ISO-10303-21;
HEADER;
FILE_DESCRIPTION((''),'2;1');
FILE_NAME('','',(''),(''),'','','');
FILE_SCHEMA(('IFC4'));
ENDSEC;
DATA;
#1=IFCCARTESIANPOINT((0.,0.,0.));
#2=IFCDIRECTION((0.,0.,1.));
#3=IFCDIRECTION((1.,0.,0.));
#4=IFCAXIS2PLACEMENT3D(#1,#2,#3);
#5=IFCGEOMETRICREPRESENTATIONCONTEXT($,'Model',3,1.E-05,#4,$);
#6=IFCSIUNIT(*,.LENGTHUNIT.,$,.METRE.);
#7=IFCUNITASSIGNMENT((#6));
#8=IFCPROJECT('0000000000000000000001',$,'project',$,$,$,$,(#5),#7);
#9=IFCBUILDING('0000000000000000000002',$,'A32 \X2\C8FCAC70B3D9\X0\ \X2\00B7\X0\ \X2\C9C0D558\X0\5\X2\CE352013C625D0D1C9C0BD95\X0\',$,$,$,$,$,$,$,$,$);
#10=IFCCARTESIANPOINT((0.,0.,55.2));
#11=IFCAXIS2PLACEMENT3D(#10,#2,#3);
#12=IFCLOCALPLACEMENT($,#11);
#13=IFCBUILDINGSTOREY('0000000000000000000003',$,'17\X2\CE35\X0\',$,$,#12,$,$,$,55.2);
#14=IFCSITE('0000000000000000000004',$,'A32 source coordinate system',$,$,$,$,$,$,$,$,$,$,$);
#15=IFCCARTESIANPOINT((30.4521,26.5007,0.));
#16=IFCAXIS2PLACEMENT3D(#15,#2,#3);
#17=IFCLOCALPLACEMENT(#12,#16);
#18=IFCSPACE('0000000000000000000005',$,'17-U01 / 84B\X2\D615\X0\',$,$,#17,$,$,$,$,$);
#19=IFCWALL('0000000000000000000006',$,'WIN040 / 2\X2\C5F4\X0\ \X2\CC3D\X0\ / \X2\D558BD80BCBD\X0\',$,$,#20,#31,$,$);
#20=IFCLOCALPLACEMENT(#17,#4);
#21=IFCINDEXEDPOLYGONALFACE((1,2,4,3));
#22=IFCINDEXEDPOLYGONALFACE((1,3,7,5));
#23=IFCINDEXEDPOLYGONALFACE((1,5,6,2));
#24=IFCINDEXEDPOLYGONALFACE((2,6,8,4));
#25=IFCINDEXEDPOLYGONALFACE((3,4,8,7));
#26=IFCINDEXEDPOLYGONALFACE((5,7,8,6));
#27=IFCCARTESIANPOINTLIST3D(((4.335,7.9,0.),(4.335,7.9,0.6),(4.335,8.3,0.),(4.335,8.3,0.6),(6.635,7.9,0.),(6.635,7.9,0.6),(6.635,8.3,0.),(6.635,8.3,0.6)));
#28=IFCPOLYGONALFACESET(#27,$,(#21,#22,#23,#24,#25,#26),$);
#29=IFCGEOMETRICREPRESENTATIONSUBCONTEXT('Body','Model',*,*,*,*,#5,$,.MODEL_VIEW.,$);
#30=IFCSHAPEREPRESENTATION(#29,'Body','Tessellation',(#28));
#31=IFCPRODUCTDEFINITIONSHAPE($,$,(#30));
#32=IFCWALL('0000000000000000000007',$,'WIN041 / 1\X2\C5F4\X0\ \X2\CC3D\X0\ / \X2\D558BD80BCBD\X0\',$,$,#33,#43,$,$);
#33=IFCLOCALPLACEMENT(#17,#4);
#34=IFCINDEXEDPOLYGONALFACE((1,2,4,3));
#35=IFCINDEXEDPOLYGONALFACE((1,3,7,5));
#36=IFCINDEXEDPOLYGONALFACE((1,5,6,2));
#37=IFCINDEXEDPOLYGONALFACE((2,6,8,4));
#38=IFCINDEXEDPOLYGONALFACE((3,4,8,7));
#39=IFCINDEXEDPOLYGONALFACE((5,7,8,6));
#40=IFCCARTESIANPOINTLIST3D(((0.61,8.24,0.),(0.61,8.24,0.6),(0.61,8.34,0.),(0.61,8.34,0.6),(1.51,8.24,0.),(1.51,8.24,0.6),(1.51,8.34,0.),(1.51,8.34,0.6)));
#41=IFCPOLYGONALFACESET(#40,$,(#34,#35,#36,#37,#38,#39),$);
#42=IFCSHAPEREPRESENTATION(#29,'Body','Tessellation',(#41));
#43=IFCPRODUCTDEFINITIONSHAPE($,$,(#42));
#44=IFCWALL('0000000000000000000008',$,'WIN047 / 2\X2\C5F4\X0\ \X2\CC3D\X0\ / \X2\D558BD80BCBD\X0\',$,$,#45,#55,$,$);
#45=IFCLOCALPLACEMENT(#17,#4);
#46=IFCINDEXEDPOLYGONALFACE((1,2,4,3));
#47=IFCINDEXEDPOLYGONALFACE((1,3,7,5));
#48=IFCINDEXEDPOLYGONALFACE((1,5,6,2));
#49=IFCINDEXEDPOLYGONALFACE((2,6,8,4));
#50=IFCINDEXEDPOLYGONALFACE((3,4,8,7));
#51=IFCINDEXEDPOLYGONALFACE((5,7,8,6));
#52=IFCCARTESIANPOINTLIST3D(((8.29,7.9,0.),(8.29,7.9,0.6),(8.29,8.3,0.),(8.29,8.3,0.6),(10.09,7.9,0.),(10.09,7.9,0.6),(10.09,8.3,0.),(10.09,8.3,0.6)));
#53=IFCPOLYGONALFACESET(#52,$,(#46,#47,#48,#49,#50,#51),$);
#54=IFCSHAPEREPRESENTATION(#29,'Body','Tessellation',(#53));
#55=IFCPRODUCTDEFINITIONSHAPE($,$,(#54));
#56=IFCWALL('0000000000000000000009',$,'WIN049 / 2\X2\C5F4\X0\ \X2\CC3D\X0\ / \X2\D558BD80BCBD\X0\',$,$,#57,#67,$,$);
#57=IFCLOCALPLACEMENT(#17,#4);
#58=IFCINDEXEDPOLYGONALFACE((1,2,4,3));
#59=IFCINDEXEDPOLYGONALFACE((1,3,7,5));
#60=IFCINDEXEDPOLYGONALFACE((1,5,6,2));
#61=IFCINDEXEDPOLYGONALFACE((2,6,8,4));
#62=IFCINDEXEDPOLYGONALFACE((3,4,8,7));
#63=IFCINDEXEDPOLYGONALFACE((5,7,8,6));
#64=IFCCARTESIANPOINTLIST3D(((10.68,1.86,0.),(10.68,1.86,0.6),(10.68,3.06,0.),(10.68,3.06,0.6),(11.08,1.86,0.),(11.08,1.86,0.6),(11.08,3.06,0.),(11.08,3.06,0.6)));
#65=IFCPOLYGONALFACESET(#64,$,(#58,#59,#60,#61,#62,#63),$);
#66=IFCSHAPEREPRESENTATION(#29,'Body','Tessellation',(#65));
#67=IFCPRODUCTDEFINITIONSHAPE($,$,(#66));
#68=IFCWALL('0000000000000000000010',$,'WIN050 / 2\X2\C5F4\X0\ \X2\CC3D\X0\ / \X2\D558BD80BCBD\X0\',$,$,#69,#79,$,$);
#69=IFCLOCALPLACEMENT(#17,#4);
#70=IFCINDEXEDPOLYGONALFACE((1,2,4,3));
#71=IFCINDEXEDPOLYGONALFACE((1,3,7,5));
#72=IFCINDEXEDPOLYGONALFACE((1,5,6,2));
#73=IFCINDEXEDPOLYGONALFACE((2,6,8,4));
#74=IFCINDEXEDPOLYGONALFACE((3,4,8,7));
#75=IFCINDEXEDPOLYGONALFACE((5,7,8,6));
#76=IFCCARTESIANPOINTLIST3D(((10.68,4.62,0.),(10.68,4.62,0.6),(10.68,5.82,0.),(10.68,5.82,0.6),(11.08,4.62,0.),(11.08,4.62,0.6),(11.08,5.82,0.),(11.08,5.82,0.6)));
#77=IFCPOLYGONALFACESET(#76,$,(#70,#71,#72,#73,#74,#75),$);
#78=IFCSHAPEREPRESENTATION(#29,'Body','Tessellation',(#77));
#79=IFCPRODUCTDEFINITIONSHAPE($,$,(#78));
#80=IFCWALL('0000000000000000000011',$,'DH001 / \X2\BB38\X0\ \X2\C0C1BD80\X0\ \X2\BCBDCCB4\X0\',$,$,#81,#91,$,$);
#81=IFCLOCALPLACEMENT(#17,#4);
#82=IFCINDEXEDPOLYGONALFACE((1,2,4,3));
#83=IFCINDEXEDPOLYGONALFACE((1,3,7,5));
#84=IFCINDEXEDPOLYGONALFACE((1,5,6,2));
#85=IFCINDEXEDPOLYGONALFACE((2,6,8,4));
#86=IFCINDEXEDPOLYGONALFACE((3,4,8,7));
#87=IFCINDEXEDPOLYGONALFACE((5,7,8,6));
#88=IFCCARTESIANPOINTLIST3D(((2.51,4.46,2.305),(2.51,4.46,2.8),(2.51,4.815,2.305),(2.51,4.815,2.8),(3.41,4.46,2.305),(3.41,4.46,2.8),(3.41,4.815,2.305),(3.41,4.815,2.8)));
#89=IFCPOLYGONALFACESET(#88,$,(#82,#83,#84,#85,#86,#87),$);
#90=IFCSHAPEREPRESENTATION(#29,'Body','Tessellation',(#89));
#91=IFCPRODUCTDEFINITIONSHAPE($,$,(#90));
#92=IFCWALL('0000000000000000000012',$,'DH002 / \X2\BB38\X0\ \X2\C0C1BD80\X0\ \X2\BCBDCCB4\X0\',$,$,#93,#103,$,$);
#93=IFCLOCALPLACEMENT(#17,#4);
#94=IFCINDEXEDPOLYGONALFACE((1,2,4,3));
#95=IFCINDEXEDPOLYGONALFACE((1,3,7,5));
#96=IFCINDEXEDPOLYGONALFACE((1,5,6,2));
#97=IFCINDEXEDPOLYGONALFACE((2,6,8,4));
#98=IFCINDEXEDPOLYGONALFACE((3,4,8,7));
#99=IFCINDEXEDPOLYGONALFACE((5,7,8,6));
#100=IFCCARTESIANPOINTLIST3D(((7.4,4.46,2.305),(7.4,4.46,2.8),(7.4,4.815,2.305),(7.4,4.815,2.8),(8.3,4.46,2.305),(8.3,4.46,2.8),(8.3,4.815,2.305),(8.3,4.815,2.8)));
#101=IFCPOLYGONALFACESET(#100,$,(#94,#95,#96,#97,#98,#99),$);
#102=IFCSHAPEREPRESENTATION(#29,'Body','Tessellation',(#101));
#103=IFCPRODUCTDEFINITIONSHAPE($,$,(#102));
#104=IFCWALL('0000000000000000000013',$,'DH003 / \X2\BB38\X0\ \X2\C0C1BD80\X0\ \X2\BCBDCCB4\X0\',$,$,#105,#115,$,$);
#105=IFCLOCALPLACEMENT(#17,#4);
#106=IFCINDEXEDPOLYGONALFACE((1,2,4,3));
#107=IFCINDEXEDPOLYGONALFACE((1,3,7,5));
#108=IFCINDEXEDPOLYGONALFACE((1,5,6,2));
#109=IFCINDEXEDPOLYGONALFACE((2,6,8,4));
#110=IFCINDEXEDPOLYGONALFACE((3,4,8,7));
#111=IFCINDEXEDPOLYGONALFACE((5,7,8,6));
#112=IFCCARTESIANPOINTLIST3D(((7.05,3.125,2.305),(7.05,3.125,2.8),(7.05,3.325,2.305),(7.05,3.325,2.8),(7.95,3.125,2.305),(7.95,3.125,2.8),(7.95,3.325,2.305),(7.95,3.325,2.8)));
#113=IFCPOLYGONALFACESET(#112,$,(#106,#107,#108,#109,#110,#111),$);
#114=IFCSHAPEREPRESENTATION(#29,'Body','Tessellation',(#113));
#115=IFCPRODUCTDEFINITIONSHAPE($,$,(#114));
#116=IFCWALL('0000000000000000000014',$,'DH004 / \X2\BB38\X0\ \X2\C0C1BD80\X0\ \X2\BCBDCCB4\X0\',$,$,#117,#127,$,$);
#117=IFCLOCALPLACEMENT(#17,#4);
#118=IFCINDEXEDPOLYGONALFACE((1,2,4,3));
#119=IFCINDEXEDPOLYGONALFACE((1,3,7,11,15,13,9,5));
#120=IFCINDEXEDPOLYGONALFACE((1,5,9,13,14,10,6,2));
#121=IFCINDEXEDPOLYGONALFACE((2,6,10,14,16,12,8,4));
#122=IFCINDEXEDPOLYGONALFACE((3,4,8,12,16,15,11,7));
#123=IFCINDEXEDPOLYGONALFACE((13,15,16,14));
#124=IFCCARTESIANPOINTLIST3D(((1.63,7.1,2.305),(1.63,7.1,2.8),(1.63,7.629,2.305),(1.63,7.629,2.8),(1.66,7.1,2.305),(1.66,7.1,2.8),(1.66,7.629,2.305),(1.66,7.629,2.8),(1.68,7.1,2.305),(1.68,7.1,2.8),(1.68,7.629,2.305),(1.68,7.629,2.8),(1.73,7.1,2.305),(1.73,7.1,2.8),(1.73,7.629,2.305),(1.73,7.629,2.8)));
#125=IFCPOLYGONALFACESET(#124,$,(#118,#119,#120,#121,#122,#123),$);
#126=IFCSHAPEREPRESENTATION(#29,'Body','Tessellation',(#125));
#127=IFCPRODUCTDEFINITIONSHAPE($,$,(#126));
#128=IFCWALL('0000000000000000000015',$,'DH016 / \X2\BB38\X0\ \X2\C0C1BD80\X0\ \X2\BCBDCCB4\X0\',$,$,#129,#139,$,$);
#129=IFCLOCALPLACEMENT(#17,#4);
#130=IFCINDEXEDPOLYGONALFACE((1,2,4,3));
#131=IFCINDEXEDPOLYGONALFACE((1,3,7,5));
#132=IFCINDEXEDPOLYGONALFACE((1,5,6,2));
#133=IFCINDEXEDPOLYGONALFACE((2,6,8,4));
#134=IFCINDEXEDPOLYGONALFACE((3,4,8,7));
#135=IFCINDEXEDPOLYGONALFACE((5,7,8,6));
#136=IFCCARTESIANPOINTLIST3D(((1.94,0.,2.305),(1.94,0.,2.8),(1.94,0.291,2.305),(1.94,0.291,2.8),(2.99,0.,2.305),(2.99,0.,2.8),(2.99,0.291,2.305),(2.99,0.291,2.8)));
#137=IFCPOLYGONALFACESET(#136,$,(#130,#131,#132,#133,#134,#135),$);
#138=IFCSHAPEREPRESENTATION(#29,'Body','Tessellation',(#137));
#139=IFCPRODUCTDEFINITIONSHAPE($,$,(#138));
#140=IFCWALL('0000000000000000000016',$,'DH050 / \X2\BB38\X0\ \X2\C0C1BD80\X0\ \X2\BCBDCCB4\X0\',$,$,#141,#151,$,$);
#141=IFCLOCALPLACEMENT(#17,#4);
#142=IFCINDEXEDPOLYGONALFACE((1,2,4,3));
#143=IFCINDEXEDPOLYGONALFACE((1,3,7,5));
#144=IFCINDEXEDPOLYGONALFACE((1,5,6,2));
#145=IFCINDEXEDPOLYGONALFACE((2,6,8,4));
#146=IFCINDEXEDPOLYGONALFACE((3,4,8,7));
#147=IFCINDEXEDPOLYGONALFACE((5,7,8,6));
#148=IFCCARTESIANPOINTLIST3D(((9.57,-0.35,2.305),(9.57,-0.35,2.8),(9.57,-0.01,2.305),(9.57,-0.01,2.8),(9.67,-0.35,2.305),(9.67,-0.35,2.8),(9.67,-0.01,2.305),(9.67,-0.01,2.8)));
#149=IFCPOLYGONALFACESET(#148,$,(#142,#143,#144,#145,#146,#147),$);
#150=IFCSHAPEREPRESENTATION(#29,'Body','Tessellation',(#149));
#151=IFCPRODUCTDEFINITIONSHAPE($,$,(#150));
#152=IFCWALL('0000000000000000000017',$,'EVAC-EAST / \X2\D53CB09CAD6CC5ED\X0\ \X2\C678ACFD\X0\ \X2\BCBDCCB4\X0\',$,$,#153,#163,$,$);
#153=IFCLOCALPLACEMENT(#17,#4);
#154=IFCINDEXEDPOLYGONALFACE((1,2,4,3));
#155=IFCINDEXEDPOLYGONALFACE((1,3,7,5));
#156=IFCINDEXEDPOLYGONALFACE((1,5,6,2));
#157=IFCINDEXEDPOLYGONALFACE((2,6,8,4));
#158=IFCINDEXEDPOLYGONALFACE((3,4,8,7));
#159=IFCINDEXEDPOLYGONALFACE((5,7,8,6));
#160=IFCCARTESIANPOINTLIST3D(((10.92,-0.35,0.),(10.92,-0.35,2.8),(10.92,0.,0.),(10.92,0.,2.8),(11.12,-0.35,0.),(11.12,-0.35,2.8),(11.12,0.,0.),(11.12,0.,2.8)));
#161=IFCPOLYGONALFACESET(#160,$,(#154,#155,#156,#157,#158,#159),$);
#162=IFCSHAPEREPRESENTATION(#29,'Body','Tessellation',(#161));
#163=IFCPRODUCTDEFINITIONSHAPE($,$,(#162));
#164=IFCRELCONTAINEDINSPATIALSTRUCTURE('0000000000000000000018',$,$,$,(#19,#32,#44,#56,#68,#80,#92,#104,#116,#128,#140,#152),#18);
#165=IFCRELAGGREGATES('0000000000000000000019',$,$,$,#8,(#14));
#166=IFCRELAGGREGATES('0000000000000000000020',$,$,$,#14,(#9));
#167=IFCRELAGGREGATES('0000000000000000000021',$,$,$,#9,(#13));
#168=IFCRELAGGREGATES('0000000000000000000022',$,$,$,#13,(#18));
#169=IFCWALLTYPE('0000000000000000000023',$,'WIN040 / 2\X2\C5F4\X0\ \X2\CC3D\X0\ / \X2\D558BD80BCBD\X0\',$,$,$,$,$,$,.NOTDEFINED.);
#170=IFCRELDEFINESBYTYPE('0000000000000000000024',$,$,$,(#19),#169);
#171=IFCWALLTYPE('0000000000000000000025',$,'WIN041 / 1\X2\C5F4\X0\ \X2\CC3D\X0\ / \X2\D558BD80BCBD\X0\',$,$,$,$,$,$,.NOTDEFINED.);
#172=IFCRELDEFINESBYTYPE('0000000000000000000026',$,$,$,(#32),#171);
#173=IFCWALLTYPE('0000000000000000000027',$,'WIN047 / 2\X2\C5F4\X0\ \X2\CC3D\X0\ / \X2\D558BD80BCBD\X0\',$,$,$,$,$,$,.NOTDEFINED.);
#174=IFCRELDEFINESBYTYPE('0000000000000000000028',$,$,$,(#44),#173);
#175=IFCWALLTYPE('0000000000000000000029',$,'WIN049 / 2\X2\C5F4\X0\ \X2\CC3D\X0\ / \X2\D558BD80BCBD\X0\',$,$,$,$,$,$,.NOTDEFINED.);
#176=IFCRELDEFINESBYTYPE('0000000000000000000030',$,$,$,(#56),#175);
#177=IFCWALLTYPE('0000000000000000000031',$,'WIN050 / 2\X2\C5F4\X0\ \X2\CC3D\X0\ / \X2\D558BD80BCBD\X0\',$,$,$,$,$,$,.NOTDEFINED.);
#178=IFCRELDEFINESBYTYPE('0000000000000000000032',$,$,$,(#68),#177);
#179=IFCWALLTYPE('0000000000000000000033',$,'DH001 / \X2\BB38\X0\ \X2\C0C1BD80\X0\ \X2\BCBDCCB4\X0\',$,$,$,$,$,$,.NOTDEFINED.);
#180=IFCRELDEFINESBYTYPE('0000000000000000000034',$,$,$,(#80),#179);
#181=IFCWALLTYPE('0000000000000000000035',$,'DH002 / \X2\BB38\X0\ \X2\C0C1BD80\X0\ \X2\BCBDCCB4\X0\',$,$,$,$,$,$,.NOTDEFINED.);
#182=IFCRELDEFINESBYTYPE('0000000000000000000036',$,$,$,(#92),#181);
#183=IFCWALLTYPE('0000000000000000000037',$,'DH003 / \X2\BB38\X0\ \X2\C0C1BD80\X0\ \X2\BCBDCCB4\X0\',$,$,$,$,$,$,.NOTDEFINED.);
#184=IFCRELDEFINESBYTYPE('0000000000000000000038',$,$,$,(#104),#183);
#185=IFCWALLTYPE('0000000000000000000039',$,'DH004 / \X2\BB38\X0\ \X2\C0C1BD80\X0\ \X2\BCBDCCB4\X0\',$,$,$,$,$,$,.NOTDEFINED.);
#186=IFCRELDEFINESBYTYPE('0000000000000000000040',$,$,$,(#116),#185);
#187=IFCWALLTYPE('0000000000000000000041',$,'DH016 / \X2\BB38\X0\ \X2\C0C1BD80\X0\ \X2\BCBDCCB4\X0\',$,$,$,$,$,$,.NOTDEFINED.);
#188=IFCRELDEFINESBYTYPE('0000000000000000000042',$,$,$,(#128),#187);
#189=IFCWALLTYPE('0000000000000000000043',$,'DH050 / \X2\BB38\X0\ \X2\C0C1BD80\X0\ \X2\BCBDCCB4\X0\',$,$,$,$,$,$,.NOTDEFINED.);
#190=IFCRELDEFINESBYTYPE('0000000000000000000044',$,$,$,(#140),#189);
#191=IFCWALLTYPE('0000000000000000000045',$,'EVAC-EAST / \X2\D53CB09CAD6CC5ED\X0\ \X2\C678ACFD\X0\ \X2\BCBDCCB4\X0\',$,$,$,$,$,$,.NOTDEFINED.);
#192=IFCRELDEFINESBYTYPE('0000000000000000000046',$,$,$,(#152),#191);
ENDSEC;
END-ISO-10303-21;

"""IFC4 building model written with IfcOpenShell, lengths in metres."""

from ifc_helpers import new_model, si_unit, frame, origin, origin_with_axes, place, context, subcontext, project, spatial, polyline, outline, extrude, source, transform, mapped, type_object, type_shapes, element, save


model = new_model("IFC4")

# Units and contexts
model_context = context("Model", 3, precision=1e-05, world=origin_with_axes())
body_context = subcontext(model_context, "Body", "Model", "MODEL_VIEW")
ifc_project = project(units=[si_unit("LENGTHUNIT", "METRE")], contexts=[model_context])

# Site, building, storey, space
site = spatial("IfcSite", under=ifc_project, Name="A32 source coordinate system")
building = spatial("IfcBuilding", under=site, Name="A32 주거동 · 지하5층–옥탑지붕")
storey_placement = place(None, frame((0.0, 0.0, 55.2), z_axis=(0.0, 0.0, 1.0), x_axis=(1.0, 0.0, 0.0)))
storey = spatial("IfcBuildingStorey", under=building, at=storey_placement, Name="17층", Elevation=55.2)
space_placement = place(storey_placement, frame((30.4521, 26.5007, 0.0), z_axis=(0.0, 0.0, 1.0), x_axis=(1.0, 0.0, 0.0)))
space = spatial("IfcSpace", under=storey, at=space_placement, Name="17-U01 / 84B형")

# Walls
wall_type_1 = type_object("IfcWallType", Name="WIN040 / 2열 창 / 하부벽", PredefinedType="NOTDEFINED")
shared_shape_1 = source(origin(), body_context, "Body", "SweptSolid", [
    extrude(outline(polyline([(4.335, 8.3), (6.635, 8.3), (6.635, 7.9), (4.335, 7.9), (4.335, 8.3)])), origin(), (0.0, 0.0, 1.0), 0.6),
])
type_shapes(wall_type_1, [shared_shape_1])
wall_1_placement = place(space_placement, origin_with_axes())
element("IfcWall", 1, at=wall_1_placement, inside=space, type_object=wall_type_1, Name="WIN040 / 2열 창 / 하부벽", context=body_context, shape_type="MappedRepresentation", body=[
    mapped(shared_shape_1, transform((0.0, 0.0, 0.0), scale=1.0)),
])
wall_type_2 = type_object("IfcWallType", Name="WIN041 / 1열 창 / 하부벽", PredefinedType="NOTDEFINED")
shared_shape_2 = source(origin(), body_context, "Body", "SweptSolid", [
    extrude(outline(polyline([(0.61, 8.34), (1.51, 8.34), (1.51, 8.24), (0.61, 8.24), (0.61, 8.34)])), origin(), (0.0, 0.0, 1.0), 0.6),
])
type_shapes(wall_type_2, [shared_shape_2])
wall_2_placement = place(space_placement, origin_with_axes())
element("IfcWall", 2, at=wall_2_placement, inside=space, type_object=wall_type_2, Name="WIN041 / 1열 창 / 하부벽", context=body_context, shape_type="MappedRepresentation", body=[
    mapped(shared_shape_2, transform((0.0, 0.0, 0.0), scale=1.0)),
])
wall_type_3 = type_object("IfcWallType", Name="WIN047 / 2열 창 / 하부벽", PredefinedType="NOTDEFINED")
shared_shape_3 = source(origin(), body_context, "Body", "SweptSolid", [
    extrude(outline(polyline([(8.29, 8.3), (10.09, 8.3), (10.09, 7.9), (8.29, 7.9), (8.29, 8.3)])), origin(), (0.0, 0.0, 1.0), 0.6),
])
type_shapes(wall_type_3, [shared_shape_3])
wall_3_placement = place(space_placement, origin_with_axes())
element("IfcWall", 3, at=wall_3_placement, inside=space, type_object=wall_type_3, Name="WIN047 / 2열 창 / 하부벽", context=body_context, shape_type="MappedRepresentation", body=[
    mapped(shared_shape_3, transform((0.0, 0.0, 0.0), scale=1.0)),
])
wall_type_4 = type_object("IfcWallType", Name="WIN049 / 2열 창 / 하부벽", PredefinedType="NOTDEFINED")
shared_shape_4 = source(origin(), body_context, "Body", "SweptSolid", [
    extrude(outline(polyline([(10.68, 3.06), (11.08, 3.06), (11.08, 1.86), (10.68, 1.86), (10.68, 3.06)])), origin(), (0.0, 0.0, 1.0), 0.6),
])
type_shapes(wall_type_4, [shared_shape_4])
wall_4_placement = place(space_placement, origin_with_axes())
element("IfcWall", 4, at=wall_4_placement, inside=space, type_object=wall_type_4, Name="WIN049 / 2열 창 / 하부벽", context=body_context, shape_type="MappedRepresentation", body=[
    mapped(shared_shape_4, transform((0.0, 0.0, 0.0), scale=1.0)),
])
wall_type_5 = type_object("IfcWallType", Name="WIN050 / 2열 창 / 하부벽", PredefinedType="NOTDEFINED")
shared_shape_5 = source(origin(), body_context, "Body", "SweptSolid", [
    extrude(outline(polyline([(10.68, 5.82), (11.08, 5.82), (11.08, 4.62), (10.68, 4.62), (10.68, 5.82)])), origin(), (0.0, 0.0, 1.0), 0.6),
])
type_shapes(wall_type_5, [shared_shape_5])
wall_5_placement = place(space_placement, origin_with_axes())
element("IfcWall", 5, at=wall_5_placement, inside=space, type_object=wall_type_5, Name="WIN050 / 2열 창 / 하부벽", context=body_context, shape_type="MappedRepresentation", body=[
    mapped(shared_shape_5, transform((0.0, 0.0, 0.0), scale=1.0)),
])
wall_type_6 = type_object("IfcWallType", Name="DH001 / 문 상부 벽체", PredefinedType="NOTDEFINED")
shared_shape_6 = source(origin(), body_context, "Body", "SweptSolid", [
    extrude(outline(polyline([(3.41, 4.815), (3.41, 4.46), (2.51, 4.46), (2.51, 4.815), (3.41, 4.815)])), frame((0.0, 0.0, 2.305)), (0.0, 0.0, 1.0), 0.495),
])
type_shapes(wall_type_6, [shared_shape_6])
wall_6_placement = place(space_placement, origin_with_axes())
element("IfcWall", 6, at=wall_6_placement, inside=space, type_object=wall_type_6, Name="DH001 / 문 상부 벽체", context=body_context, shape_type="MappedRepresentation", body=[
    mapped(shared_shape_6, transform((0.0, 0.0, 0.0), scale=1.0)),
])
wall_type_7 = type_object("IfcWallType", Name="DH002 / 문 상부 벽체", PredefinedType="NOTDEFINED")
shared_shape_7 = source(origin(), body_context, "Body", "SweptSolid", [
    extrude(outline(polyline([(8.3, 4.815), (8.3, 4.46), (7.4, 4.46), (7.4, 4.815), (8.3, 4.815)])), frame((0.0, 0.0, 2.305)), (0.0, 0.0, 1.0), 0.495),
])
type_shapes(wall_type_7, [shared_shape_7])
wall_7_placement = place(space_placement, origin_with_axes())
element("IfcWall", 7, at=wall_7_placement, inside=space, type_object=wall_type_7, Name="DH002 / 문 상부 벽체", context=body_context, shape_type="MappedRepresentation", body=[
    mapped(shared_shape_7, transform((0.0, 0.0, 0.0), scale=1.0)),
])
wall_type_8 = type_object("IfcWallType", Name="DH003 / 문 상부 벽체", PredefinedType="NOTDEFINED")
shared_shape_8 = source(origin(), body_context, "Body", "SweptSolid", [
    extrude(outline(polyline([(7.95, 3.325), (7.95, 3.125), (7.05, 3.125), (7.05, 3.325), (7.95, 3.325)])), frame((0.0, 0.0, 2.305)), (0.0, 0.0, 1.0), 0.495),
])
type_shapes(wall_type_8, [shared_shape_8])
wall_8_placement = place(space_placement, origin_with_axes())
element("IfcWall", 8, at=wall_8_placement, inside=space, type_object=wall_type_8, Name="DH003 / 문 상부 벽체", context=body_context, shape_type="MappedRepresentation", body=[
    mapped(shared_shape_8, transform((0.0, 0.0, 0.0), scale=1.0)),
])
wall_type_9 = type_object("IfcWallType", Name="DH004 / 문 상부 벽체", PredefinedType="NOTDEFINED")
shared_shape_9 = source(origin(), body_context, "Body", "SweptSolid", [
    extrude(outline(polyline([(1.66, 7.1), (1.63, 7.1), (1.63, 7.629), (1.66, 7.629), (1.68, 7.629), (1.73, 7.629), (1.73, 7.1), (1.68, 7.1), (1.66, 7.1)])), frame((0.0, 0.0, 2.305)), (0.0, 0.0, 1.0), 0.495),
])
type_shapes(wall_type_9, [shared_shape_9])
wall_9_placement = place(space_placement, origin_with_axes())
element("IfcWall", 9, at=wall_9_placement, inside=space, type_object=wall_type_9, Name="DH004 / 문 상부 벽체", context=body_context, shape_type="MappedRepresentation", body=[
    mapped(shared_shape_9, transform((0.0, 0.0, 0.0), scale=1.0)),
])
wall_type_10 = type_object("IfcWallType", Name="DH016 / 문 상부 벽체", PredefinedType="NOTDEFINED")
shared_shape_10 = source(origin(), body_context, "Body", "SweptSolid", [
    extrude(outline(polyline([(2.99, 0.291), (2.99, 0.0), (1.94, 0.0), (1.94, 0.291), (2.99, 0.291)])), frame((0.0, 0.0, 2.305)), (0.0, 0.0, 1.0), 0.495),
])
type_shapes(wall_type_10, [shared_shape_10])
wall_10_placement = place(space_placement, origin_with_axes())
element("IfcWall", 10, at=wall_10_placement, inside=space, type_object=wall_type_10, Name="DH016 / 문 상부 벽체", context=body_context, shape_type="MappedRepresentation", body=[
    mapped(shared_shape_10, transform((0.0, 0.0, 0.0), scale=1.0)),
])
wall_type_11 = type_object("IfcWallType", Name="DH050 / 문 상부 벽체", PredefinedType="NOTDEFINED")
shared_shape_11 = source(origin(), body_context, "Body", "SweptSolid", [
    extrude(outline(polyline([(9.67, -0.01), (9.67, -0.35), (9.57, -0.35), (9.57, -0.01), (9.67, -0.01)])), frame((0.0, 0.0, 2.305)), (0.0, 0.0, 1.0), 0.495),
])
type_shapes(wall_type_11, [shared_shape_11])
wall_11_placement = place(space_placement, origin_with_axes())
element("IfcWall", 11, at=wall_11_placement, inside=space, type_object=wall_type_11, Name="DH050 / 문 상부 벽체", context=body_context, shape_type="MappedRepresentation", body=[
    mapped(shared_shape_11, transform((0.0, 0.0, 0.0), scale=1.0)),
])
wall_type_12 = type_object("IfcWallType", Name="EVAC-EAST / 피난구역 외곽 벽체", PredefinedType="NOTDEFINED")
shared_shape_12 = source(origin(), body_context, "Body", "SweptSolid", [
    extrude(outline(polyline([(10.92, 0.0), (11.12, 0.0), (11.12, -0.35), (10.92, -0.35), (10.92, 0.0)])), origin(), (0.0, 0.0, 1.0), 2.8),
])
type_shapes(wall_type_12, [shared_shape_12])
wall_12_placement = place(space_placement, origin_with_axes())
element("IfcWall", 12, at=wall_12_placement, inside=space, type_object=wall_type_12, Name="EVAC-EAST / 피난구역 외곽 벽체", context=body_context, shape_type="MappedRepresentation", body=[
    mapped(shared_shape_12, transform((0.0, 0.0, 0.0), scale=1.0)),
])

save(model, "model.ifc")
